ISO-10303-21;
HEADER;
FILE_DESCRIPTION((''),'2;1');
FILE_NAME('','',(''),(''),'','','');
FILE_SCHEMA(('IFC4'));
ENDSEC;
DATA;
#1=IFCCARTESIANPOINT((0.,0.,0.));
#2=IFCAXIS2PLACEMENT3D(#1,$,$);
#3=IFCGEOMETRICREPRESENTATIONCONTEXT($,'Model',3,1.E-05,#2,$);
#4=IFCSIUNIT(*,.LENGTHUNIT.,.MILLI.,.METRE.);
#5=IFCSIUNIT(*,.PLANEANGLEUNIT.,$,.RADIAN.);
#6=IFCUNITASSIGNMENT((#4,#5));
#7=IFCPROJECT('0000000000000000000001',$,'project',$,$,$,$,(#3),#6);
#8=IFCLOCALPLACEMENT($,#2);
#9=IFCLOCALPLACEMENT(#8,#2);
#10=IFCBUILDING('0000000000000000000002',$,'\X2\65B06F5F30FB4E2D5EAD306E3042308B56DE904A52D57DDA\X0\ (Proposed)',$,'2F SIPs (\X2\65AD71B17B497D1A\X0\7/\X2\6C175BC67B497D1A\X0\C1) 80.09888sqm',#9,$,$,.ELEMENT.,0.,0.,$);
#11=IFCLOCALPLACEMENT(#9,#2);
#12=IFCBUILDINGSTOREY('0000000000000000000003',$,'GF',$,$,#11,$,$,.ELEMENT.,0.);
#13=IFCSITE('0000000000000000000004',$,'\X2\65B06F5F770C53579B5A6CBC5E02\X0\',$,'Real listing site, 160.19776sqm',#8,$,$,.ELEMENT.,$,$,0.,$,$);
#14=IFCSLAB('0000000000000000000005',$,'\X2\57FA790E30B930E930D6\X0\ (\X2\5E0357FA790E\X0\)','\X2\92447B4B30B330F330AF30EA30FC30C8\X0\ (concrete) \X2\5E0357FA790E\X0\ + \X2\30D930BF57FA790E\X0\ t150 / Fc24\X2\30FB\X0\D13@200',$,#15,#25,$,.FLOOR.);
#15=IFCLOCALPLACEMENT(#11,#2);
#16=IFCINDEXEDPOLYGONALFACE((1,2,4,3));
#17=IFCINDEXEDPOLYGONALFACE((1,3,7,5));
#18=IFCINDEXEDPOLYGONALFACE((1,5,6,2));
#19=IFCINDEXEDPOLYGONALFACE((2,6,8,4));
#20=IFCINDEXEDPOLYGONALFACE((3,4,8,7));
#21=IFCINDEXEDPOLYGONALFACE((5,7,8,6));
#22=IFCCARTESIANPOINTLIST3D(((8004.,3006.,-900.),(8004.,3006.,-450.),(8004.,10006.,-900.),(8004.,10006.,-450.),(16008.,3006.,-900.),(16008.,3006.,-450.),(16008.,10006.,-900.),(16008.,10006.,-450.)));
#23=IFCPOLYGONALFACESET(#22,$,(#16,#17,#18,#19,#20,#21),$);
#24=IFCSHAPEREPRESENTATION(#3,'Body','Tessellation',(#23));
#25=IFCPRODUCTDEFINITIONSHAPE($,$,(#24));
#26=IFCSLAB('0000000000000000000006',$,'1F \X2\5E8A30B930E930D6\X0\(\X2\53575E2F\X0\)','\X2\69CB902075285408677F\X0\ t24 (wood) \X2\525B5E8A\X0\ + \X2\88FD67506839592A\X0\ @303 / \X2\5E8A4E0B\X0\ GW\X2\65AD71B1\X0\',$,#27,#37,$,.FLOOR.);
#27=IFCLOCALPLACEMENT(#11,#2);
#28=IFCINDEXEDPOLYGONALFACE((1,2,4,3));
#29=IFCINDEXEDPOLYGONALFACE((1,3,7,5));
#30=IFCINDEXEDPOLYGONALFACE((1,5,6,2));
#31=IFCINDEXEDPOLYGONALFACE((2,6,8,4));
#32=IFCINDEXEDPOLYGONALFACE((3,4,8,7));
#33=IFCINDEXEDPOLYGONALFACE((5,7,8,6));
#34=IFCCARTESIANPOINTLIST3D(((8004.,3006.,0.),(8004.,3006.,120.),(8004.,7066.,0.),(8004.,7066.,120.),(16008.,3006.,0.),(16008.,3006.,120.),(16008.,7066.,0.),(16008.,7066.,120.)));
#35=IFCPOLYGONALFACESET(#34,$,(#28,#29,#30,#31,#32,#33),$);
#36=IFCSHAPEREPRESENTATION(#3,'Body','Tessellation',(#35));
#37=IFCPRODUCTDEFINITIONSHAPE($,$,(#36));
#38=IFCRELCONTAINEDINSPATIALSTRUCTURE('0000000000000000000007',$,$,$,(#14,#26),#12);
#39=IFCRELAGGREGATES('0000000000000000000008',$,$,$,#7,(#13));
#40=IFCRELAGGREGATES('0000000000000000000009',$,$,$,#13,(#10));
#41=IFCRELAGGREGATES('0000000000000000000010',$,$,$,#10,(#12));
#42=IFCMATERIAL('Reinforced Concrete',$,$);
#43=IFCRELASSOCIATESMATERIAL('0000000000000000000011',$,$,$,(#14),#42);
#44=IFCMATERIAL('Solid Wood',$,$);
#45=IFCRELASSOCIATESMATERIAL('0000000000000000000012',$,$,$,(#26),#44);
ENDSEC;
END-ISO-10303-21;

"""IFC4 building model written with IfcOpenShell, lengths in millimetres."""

from ifc_helpers import new_model, si_unit, frame, frame_2d, origin, place, context, project, spatial, rectangle, extrude, material, element, save


model = new_model("IFC4")

# Units and contexts
model_context = context("Model", 3, precision=1e-05, world=origin())
ifc_project = project(units=[si_unit("LENGTHUNIT", "METRE", prefix="MILLI"), si_unit("PLANEANGLEUNIT", "RADIAN")], contexts=[model_context])

# Site, building, storey
site_placement = place(None, origin())
site = spatial("IfcSite", under=ifc_project, at=site_placement, Name="新潟県南魚沼市", ObjectType="Real listing site, 160.19776sqm", CompositionType="ELEMENT", RefElevation=0.0)
building_placement = place(site_placement, origin())
building = spatial("IfcBuilding", under=site, at=building_placement, Name="新潟・中庭のある回遊動線 (Proposed)", ObjectType="2F SIPs (断熱等級7/気密等級C1) 80.09888sqm", CompositionType="ELEMENT", ElevationOfRefHeight=0.0, ElevationOfTerrain=0.0)
storey_placement = place(building_placement, origin())
storey = spatial("IfcBuildingStorey", under=building, at=storey_placement, Name="GF", CompositionType="ELEMENT", Elevation=0.0)

# Slabs
ifc_material_1 = material(Name="Reinforced Concrete")
slab_1_placement = place(storey_placement, frame((4002.0, 1503.0, -450.0)))
element("IfcSlab", 1, at=slab_1_placement, inside=storey, material=ifc_material_1, Name="基礎スラブ (布基礎)", Description="鉄筋コンクリート (concrete) 布基礎 + ベタ基礎 t150 / Fc24・D13@200", PredefinedType="FLOOR", context=model_context, shape_type="SweptSolid", body=[
    extrude(rectangle(XDim=8004.0, YDim=7000.0, at=frame_2d((4002.0, 3500.0))), frame((4002.0, 1503.0, -450.0)), (0.0, 0.0, 1.0), 450.0),
])
ifc_material_2 = material(Name="Solid Wood")
slab_2_placement = place(storey_placement, frame((4002.0, 1503.0, 0.0)))
element("IfcSlab", 2, at=slab_2_placement, inside=storey, material=ifc_material_2, Name="1F 床スラブ(南帯)", Description="構造用合板 t24 (wood) 剛床 + 製材根太 @303 / 床下 GW断熱", PredefinedType="FLOOR", context=model_context, shape_type="SweptSolid", body=[
    extrude(rectangle(XDim=8004.0, YDim=4060.0, at=frame_2d((4002.0, 2030.0))), frame((4002.0, 1503.0, 0.0)), (0.0, 0.0, 1.0), 120.0),
])

save(model, "model.ifc")
